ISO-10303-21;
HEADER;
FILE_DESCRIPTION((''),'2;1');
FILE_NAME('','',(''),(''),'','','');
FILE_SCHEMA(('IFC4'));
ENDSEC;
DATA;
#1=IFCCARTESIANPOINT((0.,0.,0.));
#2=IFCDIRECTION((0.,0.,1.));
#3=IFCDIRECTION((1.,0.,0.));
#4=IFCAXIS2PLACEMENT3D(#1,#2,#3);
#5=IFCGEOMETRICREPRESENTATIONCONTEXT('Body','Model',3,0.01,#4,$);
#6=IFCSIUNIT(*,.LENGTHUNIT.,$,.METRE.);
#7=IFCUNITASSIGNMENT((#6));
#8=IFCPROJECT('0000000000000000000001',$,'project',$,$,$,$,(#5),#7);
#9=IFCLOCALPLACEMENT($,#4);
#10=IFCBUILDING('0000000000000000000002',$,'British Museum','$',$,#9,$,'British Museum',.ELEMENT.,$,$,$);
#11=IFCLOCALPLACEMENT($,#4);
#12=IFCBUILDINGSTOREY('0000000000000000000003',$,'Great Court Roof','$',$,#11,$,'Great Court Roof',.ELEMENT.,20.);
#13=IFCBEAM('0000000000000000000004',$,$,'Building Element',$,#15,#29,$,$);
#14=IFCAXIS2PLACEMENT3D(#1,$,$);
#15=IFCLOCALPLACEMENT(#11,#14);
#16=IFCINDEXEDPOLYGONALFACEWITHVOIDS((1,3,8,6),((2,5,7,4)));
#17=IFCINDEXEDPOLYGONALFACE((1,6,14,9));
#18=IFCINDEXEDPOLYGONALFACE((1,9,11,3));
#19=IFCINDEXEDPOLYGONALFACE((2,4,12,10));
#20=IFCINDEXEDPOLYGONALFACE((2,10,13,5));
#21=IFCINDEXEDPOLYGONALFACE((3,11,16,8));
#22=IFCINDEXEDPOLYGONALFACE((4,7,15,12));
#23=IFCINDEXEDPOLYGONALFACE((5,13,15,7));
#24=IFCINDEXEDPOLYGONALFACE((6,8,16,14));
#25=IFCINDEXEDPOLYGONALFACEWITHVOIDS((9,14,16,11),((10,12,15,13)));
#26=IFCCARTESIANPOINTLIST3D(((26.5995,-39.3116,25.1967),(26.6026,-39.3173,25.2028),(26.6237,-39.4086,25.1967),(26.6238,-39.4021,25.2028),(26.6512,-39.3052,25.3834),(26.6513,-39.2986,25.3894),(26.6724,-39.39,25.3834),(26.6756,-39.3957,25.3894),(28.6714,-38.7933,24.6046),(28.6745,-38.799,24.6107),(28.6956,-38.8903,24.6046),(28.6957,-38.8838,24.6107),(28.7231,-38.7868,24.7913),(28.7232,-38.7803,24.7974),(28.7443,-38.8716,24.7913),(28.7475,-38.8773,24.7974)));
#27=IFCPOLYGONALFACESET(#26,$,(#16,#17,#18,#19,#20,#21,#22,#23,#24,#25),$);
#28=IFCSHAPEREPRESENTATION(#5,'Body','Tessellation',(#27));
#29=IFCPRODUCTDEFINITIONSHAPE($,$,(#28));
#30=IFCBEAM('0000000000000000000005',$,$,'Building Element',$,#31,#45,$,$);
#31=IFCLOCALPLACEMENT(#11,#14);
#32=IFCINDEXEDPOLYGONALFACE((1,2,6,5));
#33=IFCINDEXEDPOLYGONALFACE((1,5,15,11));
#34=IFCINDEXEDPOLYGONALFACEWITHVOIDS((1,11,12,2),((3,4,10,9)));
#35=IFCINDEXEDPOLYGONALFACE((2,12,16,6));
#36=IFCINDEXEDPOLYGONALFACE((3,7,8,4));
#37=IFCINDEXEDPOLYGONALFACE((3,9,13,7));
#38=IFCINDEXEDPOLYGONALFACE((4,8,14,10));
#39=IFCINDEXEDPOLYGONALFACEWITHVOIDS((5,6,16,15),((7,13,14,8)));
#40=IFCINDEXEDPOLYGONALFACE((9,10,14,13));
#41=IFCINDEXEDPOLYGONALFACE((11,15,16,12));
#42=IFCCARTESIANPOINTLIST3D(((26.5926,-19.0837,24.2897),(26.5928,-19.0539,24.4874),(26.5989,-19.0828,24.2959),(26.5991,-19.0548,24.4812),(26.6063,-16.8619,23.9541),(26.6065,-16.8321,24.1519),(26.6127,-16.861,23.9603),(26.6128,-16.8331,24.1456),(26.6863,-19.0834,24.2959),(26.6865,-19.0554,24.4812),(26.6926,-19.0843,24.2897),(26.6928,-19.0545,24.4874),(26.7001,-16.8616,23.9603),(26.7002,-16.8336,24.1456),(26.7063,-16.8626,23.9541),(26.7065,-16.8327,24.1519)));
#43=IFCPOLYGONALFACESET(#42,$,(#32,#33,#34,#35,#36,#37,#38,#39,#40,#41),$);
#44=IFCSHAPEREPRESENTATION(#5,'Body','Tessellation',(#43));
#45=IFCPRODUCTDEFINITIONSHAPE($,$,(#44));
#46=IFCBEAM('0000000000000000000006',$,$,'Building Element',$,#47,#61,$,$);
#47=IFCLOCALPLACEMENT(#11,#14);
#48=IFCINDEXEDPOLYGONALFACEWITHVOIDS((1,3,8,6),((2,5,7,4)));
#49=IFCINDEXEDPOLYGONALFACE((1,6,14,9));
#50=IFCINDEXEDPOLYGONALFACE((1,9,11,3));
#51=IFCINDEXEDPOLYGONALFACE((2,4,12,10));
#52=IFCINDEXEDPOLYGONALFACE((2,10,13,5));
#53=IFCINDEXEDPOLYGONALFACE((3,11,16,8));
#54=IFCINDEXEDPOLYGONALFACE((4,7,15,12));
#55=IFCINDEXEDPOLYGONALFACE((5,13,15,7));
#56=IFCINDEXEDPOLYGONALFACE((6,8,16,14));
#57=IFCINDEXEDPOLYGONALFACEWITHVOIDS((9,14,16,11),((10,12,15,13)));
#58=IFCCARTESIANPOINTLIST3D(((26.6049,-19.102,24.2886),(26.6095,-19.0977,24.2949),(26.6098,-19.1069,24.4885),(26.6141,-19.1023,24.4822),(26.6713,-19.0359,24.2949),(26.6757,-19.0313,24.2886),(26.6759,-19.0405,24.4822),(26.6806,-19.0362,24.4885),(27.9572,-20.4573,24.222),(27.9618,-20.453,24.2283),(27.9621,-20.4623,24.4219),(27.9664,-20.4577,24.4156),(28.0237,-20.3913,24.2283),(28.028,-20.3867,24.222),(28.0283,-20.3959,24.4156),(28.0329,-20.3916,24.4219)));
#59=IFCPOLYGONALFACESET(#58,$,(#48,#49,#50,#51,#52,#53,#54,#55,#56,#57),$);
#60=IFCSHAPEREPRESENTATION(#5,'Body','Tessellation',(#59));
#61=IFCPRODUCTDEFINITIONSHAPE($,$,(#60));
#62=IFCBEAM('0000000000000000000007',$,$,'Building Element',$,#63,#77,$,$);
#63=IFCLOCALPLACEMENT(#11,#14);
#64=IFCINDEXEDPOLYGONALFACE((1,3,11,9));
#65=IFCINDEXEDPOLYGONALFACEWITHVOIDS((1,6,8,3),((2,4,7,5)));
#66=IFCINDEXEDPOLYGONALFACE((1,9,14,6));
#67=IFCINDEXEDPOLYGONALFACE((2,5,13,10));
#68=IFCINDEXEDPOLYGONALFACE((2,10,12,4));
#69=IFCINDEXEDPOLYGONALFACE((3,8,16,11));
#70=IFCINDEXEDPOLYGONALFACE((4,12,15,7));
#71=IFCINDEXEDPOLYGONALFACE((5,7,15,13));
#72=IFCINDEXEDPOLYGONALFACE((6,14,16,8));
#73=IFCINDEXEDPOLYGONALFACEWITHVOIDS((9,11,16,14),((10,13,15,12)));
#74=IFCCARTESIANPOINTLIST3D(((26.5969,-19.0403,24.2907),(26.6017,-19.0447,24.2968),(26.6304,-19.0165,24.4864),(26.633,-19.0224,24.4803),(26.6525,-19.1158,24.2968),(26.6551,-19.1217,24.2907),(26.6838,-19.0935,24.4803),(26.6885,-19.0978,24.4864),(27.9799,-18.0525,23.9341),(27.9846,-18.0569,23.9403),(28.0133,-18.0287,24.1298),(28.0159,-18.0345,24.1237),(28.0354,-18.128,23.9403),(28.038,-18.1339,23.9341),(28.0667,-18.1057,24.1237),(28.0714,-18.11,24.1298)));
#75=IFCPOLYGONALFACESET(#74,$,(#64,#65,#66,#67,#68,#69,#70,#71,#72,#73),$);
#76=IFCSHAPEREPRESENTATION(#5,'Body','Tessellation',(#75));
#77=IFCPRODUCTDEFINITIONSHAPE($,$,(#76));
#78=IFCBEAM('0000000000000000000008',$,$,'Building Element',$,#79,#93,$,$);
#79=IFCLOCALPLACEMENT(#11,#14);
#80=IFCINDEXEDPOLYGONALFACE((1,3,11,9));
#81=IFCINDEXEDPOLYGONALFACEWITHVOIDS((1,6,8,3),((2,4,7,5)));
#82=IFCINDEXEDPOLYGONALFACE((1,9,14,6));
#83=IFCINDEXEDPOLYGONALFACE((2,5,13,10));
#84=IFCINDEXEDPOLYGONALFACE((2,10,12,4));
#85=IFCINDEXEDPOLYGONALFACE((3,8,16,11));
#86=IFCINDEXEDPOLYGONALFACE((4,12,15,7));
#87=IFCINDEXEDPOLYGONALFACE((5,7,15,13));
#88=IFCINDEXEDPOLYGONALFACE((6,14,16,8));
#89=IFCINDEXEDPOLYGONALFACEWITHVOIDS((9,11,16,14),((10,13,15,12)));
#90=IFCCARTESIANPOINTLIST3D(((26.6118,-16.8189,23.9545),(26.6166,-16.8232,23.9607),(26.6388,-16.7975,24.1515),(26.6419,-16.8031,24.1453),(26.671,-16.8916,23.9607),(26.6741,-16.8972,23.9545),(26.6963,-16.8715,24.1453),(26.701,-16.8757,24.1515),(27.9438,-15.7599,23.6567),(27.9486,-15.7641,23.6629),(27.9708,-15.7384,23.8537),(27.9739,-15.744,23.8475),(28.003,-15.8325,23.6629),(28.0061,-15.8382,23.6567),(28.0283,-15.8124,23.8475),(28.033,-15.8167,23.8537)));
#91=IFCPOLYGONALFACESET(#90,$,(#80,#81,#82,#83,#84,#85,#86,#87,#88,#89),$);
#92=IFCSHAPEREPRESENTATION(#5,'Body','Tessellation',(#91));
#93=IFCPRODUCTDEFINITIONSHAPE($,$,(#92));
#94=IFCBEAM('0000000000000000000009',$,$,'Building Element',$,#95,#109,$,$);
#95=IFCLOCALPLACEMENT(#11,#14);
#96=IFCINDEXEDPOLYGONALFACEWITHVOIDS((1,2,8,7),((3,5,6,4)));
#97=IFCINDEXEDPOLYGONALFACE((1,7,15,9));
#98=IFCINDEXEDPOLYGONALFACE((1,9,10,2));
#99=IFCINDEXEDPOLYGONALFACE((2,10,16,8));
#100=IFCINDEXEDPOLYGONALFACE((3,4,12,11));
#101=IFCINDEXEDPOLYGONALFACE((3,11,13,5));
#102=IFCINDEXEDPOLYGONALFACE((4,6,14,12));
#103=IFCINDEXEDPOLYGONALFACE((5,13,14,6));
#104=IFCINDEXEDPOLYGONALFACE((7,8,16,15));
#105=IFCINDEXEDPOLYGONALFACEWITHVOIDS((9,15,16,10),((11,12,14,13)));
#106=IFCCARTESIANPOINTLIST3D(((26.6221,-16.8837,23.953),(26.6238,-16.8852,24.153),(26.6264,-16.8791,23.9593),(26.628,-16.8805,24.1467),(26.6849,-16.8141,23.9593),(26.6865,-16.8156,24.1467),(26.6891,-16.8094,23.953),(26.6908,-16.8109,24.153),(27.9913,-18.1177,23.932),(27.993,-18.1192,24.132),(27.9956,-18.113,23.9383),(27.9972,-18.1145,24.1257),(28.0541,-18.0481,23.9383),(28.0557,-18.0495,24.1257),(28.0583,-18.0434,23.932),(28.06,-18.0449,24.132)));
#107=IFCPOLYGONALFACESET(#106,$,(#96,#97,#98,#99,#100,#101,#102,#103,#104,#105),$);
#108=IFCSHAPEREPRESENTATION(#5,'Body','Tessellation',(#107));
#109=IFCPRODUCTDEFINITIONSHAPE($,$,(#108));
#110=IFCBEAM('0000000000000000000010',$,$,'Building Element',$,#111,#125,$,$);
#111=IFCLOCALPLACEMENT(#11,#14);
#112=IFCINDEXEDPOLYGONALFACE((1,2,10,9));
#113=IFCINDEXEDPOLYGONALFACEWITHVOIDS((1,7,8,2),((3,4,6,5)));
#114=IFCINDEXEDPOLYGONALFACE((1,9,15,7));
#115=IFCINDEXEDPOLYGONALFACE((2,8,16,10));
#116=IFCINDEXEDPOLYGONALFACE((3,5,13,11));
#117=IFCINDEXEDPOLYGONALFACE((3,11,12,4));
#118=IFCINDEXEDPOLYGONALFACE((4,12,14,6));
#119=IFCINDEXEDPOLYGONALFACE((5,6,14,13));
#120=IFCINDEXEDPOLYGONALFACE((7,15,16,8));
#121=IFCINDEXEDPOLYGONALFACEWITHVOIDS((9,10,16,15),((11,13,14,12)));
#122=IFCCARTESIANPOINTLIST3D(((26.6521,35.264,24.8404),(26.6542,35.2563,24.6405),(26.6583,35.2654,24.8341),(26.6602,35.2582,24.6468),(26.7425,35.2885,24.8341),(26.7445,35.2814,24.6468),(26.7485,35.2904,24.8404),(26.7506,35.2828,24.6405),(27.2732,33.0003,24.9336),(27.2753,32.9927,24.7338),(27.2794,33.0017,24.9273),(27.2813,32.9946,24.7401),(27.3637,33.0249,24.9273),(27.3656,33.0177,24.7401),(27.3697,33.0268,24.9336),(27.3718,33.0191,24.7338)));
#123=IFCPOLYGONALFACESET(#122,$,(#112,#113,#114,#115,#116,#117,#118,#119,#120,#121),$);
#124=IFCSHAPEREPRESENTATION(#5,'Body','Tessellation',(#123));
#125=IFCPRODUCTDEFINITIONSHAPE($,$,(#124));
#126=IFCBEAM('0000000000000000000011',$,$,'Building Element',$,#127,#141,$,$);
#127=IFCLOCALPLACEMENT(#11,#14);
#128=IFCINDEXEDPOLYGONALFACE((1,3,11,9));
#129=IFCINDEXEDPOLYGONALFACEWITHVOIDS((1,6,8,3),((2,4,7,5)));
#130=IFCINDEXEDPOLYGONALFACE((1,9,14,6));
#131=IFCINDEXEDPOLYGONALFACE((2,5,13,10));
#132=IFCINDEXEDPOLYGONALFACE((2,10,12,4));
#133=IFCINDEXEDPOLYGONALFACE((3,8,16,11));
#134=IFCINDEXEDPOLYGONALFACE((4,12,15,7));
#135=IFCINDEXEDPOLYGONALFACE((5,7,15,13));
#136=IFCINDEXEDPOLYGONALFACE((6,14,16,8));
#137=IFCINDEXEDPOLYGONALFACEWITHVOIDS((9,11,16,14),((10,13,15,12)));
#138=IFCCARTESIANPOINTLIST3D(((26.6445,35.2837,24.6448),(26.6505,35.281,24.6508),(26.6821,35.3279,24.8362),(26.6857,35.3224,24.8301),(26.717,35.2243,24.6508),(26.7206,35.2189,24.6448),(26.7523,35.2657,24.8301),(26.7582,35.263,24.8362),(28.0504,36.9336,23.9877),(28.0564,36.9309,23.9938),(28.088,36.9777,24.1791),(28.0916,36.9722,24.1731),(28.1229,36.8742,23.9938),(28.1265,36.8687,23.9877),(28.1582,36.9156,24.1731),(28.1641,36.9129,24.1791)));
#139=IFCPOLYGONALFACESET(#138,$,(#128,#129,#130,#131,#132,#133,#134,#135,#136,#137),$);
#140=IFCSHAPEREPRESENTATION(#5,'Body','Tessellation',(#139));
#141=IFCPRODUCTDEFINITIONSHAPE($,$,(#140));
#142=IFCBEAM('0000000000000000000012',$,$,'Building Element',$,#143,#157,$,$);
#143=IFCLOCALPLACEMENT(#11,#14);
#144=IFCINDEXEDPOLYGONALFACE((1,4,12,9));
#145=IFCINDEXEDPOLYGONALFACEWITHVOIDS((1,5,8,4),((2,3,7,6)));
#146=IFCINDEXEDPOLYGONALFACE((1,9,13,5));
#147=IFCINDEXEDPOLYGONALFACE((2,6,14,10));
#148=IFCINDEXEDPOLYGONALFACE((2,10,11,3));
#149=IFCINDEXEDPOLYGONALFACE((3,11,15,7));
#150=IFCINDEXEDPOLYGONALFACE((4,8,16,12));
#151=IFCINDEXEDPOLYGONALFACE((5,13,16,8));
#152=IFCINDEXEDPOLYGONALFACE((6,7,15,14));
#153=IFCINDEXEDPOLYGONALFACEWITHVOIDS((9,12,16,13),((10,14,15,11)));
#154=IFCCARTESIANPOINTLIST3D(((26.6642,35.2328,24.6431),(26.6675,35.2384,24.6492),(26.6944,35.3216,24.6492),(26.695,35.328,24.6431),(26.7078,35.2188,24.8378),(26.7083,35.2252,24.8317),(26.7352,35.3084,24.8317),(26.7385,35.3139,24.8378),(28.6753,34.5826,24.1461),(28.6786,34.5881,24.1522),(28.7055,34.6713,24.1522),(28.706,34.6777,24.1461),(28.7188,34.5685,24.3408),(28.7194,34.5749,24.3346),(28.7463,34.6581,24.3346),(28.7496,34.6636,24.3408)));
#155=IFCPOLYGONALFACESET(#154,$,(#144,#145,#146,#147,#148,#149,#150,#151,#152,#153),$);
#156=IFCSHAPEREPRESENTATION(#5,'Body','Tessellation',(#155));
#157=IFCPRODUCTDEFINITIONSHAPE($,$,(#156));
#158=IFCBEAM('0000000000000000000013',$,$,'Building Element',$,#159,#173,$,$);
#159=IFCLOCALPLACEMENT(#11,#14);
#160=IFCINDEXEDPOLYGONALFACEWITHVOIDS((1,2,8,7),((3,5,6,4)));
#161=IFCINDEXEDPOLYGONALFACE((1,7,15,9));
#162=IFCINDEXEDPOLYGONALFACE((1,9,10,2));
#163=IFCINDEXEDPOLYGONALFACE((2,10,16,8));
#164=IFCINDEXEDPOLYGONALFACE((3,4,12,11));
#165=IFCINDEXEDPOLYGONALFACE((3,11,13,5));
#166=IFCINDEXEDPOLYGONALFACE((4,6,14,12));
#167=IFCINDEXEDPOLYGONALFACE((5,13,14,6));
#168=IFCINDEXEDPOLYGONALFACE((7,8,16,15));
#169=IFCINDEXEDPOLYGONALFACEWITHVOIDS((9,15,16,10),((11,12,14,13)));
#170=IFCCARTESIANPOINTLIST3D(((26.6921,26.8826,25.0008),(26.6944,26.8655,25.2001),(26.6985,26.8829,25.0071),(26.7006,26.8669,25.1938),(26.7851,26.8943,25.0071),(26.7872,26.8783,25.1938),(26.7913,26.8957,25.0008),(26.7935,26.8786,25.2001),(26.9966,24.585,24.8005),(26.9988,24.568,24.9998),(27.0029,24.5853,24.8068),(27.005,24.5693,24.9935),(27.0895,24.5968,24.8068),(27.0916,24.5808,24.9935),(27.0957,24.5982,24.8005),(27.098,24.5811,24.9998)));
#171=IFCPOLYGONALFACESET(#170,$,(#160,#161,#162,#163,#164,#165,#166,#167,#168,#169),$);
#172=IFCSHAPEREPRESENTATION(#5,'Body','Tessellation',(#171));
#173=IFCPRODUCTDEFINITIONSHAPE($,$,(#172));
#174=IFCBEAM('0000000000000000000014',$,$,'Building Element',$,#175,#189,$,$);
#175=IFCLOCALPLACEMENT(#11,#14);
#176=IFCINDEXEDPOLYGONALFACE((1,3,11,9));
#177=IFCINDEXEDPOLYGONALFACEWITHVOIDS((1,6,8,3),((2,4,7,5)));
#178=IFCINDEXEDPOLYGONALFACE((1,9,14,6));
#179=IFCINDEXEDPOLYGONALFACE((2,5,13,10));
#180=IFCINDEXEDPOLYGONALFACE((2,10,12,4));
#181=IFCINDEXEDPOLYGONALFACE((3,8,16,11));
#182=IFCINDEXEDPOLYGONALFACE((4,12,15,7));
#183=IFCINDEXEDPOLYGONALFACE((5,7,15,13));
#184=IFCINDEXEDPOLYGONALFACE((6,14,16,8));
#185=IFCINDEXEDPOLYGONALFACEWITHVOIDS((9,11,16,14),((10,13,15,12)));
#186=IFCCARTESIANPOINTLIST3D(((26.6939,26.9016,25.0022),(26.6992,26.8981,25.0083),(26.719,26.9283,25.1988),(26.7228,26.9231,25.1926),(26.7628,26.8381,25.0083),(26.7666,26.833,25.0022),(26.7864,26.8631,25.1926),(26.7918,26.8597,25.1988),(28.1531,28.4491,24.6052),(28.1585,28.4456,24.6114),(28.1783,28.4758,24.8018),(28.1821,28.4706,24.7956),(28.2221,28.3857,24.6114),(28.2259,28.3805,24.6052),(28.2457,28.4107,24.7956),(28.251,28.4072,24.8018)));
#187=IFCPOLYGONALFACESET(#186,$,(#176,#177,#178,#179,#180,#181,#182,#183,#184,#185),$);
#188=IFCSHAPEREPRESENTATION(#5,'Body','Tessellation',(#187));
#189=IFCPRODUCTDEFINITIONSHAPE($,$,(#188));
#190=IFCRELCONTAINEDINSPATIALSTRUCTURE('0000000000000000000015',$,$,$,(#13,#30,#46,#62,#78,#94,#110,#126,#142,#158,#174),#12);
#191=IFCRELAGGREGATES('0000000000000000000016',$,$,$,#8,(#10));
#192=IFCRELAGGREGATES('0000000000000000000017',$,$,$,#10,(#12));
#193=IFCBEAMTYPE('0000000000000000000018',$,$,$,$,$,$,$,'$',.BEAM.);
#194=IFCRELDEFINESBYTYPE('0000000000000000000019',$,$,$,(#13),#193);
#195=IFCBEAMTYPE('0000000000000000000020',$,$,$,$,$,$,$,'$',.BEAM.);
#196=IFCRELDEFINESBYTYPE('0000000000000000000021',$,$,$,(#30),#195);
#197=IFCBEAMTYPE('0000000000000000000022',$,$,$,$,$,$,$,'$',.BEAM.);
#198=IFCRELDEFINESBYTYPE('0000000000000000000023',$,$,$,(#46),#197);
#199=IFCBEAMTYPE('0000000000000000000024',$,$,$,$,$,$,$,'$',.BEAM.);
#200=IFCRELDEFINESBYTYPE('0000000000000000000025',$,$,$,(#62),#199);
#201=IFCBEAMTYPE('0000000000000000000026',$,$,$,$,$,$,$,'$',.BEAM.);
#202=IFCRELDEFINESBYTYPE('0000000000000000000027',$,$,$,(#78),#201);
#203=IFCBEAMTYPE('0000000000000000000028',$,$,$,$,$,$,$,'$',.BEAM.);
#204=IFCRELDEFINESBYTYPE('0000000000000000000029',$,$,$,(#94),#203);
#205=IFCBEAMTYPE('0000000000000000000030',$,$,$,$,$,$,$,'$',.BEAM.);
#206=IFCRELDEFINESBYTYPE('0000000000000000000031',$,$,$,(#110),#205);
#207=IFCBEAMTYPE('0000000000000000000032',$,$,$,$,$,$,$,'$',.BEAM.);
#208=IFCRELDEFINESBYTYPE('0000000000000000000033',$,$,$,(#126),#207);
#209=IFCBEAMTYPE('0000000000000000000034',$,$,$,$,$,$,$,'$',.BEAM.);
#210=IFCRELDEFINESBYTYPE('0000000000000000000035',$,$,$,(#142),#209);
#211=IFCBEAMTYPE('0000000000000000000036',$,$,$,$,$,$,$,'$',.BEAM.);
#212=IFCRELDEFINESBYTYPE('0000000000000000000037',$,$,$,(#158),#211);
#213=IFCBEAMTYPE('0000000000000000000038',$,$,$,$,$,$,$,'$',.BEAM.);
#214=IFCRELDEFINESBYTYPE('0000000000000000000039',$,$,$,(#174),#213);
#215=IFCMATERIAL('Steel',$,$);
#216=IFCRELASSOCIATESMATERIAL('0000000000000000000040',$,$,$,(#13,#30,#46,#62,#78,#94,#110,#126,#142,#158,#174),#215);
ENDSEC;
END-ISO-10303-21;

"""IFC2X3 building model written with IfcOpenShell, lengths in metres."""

from ifc_helpers import new_model, si_unit, frame, origin_with_axes, origin_2d, place, context, project, spatial, hollow_rectangle, extrude, material, type_object, element, save


model = new_model("IFC2X3")

# Units and contexts
model_context = context("Model", 3, precision=0.01, world=origin_with_axes(), identifier="Body")
ifc_project = project(units=[si_unit("LENGTHUNIT", "METRE")], contexts=[model_context])

# Building, storey
building_placement = place(None, origin_with_axes())
building = spatial("IfcBuilding", under=ifc_project, at=building_placement, Name="British Museum", Description="$", LongName="British Museum", CompositionType="ELEMENT")
storey_placement = place(None, origin_with_axes())
storey = spatial("IfcBuildingStorey", under=building, at=storey_placement, Name="Great Court Roof", Description="$", LongName="Great Court Roof", CompositionType="ELEMENT", Elevation=20.0)

# Beams
ifc_material = material(Name="Steel")
beam_type_1 = type_object("IfcBeamType", ElementType="$", PredefinedType="BEAM")
beam_1_placement = place(None, origin_with_axes())
element("IfcBeam", 1, at=beam_1_placement, inside=storey, type_object=beam_type_1, material=ifc_material, Description="Building Element", context=model_context, shape_type="SweptSolid", body=[
    extrude(hollow_rectangle(XDim=0.1, YDim=0.2, WallThickness=0.0063, InnerFilletRadius=-0.0063, OuterFilletRadius=0.0, at=origin_2d()), frame((26.6375, -39.3536, 25.2931), z_axis=(0.934843, 0.233871, -0.267156), x_axis=(-0.242692, 0.970103, 0.0)), (0.0, 0.0, 1.0), 2.2163),
])
beam_type_2 = type_object("IfcBeamType", ElementType="$", PredefinedType="BEAM")
beam_2_placement = place(None, origin_with_axes())
element("IfcBeam", 2, at=beam_2_placement, inside=storey, type_object=beam_type_2, material=ifc_material, Description="Building Element", context=model_context, shape_type="SweptSolid", body=[
    extrude(hollow_rectangle(XDim=0.1, YDim=0.2, WallThickness=0.0063, InnerFilletRadius=-0.0063, OuterFilletRadius=0.0, at=origin_2d()), frame((26.6427, -19.0691, 24.3885), z_axis=(0.006109, 0.988767, -0.149339), x_axis=(-0.999981, 0.006178, 0.0)), (0.0, 0.0, 1.0), 2.247),
])
beam_type_3 = type_object("IfcBeamType", ElementType="$", PredefinedType="BEAM")
beam_3_placement = place(None, origin_with_axes())
element("IfcBeam", 3, at=beam_3_placement, inside=storey, type_object=beam_type_3, material=ifc_material, Description="Building Element", context=model_context, shape_type="SweptSolid", body=[
    extrude(hollow_rectangle(XDim=0.1, YDim=0.2, WallThickness=0.0063, InnerFilletRadius=-0.0063, OuterFilletRadius=0.0, at=origin_2d()), frame((26.6427, -19.0691, 24.3885), z_axis=(0.705882, -0.707477, -0.034746), x_axis=(0.707904, 0.706308, 0.0)), (0.0, 0.0, 1.0), 1.9158),
])
beam_type_4 = type_object("IfcBeamType", ElementType="$", PredefinedType="BEAM")
beam_4_placement = place(None, origin_with_axes())
element("IfcBeam", 4, at=beam_4_placement, inside=storey, type_object=beam_type_4, material=ifc_material, Description="Building Element", context=model_context, shape_type="SweptSolid", body=[
    extrude(hollow_rectangle(XDim=0.1, YDim=0.2, WallThickness=0.0063, InnerFilletRadius=-0.0063, OuterFilletRadius=0.0, at=origin_2d()), frame((26.6427, -19.0691, 24.3885), z_axis=(0.796387, 0.56886, -0.205342), x_axis=(-0.581246, 0.813728, 0.0)), (0.0, 0.0, 1.0), 1.7365),
])
beam_type_5 = type_object("IfcBeamType", ElementType="$", PredefinedType="BEAM")
beam_5_placement = place(None, origin_with_axes())
element("IfcBeam", 5, at=beam_5_placement, inside=storey, type_object=beam_type_5, material=ifc_material, Description="Building Element", context=model_context, shape_type="SweptSolid", body=[
    extrude(hollow_rectangle(XDim=0.1, YDim=0.2, WallThickness=0.0063, InnerFilletRadius=-0.0063, OuterFilletRadius=0.0, at=origin_2d()), frame((26.6564, -16.8473, 24.053), z_axis=(0.771038, 0.613023, -0.172347), x_axis=(-0.622335, 0.782751, 0.0)), (0.0, 0.0, 1.0), 1.7275),
])
beam_type_6 = type_object("IfcBeamType", ElementType="$", PredefinedType="BEAM")
beam_6_placement = place(None, origin_with_axes())
element("IfcBeam", 6, at=beam_6_placement, inside=storey, type_object=beam_type_6, material=ifc_material, Description="Building Element", context=model_context, shape_type="SweptSolid", body=[
    extrude(hollow_rectangle(XDim=0.1, YDim=0.2, WallThickness=0.0063, InnerFilletRadius=-0.0063, OuterFilletRadius=0.0, at=origin_2d()), frame((26.6564, -16.8473, 24.053), z_axis=(0.74279, -0.669427, -0.011396), x_axis=(0.669471, 0.742838, 0.0)), (0.0, 0.0, 1.0), 1.8433),
])
beam_type_7 = type_object("IfcBeamType", ElementType="$", PredefinedType="BEAM")
beam_7_placement = place(None, origin_with_axes())
element("IfcBeam", 7, at=beam_7_placement, inside=storey, type_object=beam_type_7, material=ifc_material, Description="Building Element", context=model_context, shape_type="SweptSolid", body=[
    extrude(hollow_rectangle(XDim=0.1, YDim=0.2, WallThickness=0.0063, InnerFilletRadius=-0.0063, OuterFilletRadius=0.0, at=origin_2d()), frame((26.7014, 35.2734, 24.7405), z_axis=(0.264396, -0.963597, 0.039687), x_axis=(0.964357, 0.264604, 0.0)), (0.0, 0.0, 1.0), 2.3492),
])
beam_type_8 = type_object("IfcBeamType", ElementType="$", PredefinedType="BEAM")
beam_8_placement = place(None, origin_with_axes())
element("IfcBeam", 8, at=beam_8_placement, inside=storey, type_object=beam_type_8, material=ifc_material, Description="Building Element", context=model_context, shape_type="SweptSolid", body=[
    extrude(hollow_rectangle(XDim=0.1, YDim=0.2, WallThickness=0.0063, InnerFilletRadius=-0.0063, OuterFilletRadius=0.0, at=origin_2d()), frame((26.7014, 35.2734, 24.7405), z_axis=(0.62071, 0.728406, -0.290076), x_axis=(-0.761132, 0.648597, 0.0)), (0.0, 0.0, 1.0), 2.265),
])
beam_type_9 = type_object("IfcBeamType", ElementType="$", PredefinedType="BEAM")
beam_9_placement = place(None, origin_with_axes())
element("IfcBeam", 9, at=beam_9_placement, inside=storey, type_object=beam_type_9, material=ifc_material, Description="Building Element", context=model_context, shape_type="SweptSolid", body=[
    extrude(hollow_rectangle(XDim=0.1, YDim=0.2, WallThickness=0.0063, InnerFilletRadius=-0.0063, OuterFilletRadius=0.0, at=origin_2d()), frame((26.7014, 35.2734, 24.7405), z_axis=(0.926229, -0.299493, -0.228917), x_axis=(0.307663, 0.951495, 0.0)), (0.0, 0.0, 1.0), 2.1712),
])
beam_type_10 = type_object("IfcBeamType", ElementType="$", PredefinedType="BEAM")
beam_10_placement = place(None, origin_with_axes())
element("IfcBeam", 10, at=beam_10_placement, inside=storey, type_object=beam_type_10, material=ifc_material, Description="Building Element", context=model_context, shape_type="SweptSolid", body=[
    extrude(hollow_rectangle(XDim=0.1, YDim=0.2, WallThickness=0.0063, InnerFilletRadius=-0.0063, OuterFilletRadius=0.0, at=origin_2d()), frame((26.7428, 26.8806, 25.1005), z_axis=(0.130869, -0.987653, -0.086113), x_axis=(0.991335, 0.131357, 0.0)), (0.0, 0.0, 1.0), 2.3262),
])
beam_type_11 = type_object("IfcBeamType", ElementType="$", PredefinedType="BEAM")
beam_11_placement = place(None, origin_with_axes())
element("IfcBeam", 11, at=beam_11_placement, inside=storey, type_object=beam_type_11, material=ifc_material, Description="Building Element", context=model_context, shape_type="SweptSolid", body=[
    extrude(hollow_rectangle(XDim=0.1, YDim=0.2, WallThickness=0.0063, InnerFilletRadius=-0.0063, OuterFilletRadius=0.0, at=origin_2d()), frame((26.7428, 26.8806, 25.1005), z_axis=(0.674399, 0.715211, -0.183464), x_axis=(-0.72756, 0.686044, 0.0)), (0.0, 0.0, 1.0), 2.1638),
])

save(model, "model.ifc")
